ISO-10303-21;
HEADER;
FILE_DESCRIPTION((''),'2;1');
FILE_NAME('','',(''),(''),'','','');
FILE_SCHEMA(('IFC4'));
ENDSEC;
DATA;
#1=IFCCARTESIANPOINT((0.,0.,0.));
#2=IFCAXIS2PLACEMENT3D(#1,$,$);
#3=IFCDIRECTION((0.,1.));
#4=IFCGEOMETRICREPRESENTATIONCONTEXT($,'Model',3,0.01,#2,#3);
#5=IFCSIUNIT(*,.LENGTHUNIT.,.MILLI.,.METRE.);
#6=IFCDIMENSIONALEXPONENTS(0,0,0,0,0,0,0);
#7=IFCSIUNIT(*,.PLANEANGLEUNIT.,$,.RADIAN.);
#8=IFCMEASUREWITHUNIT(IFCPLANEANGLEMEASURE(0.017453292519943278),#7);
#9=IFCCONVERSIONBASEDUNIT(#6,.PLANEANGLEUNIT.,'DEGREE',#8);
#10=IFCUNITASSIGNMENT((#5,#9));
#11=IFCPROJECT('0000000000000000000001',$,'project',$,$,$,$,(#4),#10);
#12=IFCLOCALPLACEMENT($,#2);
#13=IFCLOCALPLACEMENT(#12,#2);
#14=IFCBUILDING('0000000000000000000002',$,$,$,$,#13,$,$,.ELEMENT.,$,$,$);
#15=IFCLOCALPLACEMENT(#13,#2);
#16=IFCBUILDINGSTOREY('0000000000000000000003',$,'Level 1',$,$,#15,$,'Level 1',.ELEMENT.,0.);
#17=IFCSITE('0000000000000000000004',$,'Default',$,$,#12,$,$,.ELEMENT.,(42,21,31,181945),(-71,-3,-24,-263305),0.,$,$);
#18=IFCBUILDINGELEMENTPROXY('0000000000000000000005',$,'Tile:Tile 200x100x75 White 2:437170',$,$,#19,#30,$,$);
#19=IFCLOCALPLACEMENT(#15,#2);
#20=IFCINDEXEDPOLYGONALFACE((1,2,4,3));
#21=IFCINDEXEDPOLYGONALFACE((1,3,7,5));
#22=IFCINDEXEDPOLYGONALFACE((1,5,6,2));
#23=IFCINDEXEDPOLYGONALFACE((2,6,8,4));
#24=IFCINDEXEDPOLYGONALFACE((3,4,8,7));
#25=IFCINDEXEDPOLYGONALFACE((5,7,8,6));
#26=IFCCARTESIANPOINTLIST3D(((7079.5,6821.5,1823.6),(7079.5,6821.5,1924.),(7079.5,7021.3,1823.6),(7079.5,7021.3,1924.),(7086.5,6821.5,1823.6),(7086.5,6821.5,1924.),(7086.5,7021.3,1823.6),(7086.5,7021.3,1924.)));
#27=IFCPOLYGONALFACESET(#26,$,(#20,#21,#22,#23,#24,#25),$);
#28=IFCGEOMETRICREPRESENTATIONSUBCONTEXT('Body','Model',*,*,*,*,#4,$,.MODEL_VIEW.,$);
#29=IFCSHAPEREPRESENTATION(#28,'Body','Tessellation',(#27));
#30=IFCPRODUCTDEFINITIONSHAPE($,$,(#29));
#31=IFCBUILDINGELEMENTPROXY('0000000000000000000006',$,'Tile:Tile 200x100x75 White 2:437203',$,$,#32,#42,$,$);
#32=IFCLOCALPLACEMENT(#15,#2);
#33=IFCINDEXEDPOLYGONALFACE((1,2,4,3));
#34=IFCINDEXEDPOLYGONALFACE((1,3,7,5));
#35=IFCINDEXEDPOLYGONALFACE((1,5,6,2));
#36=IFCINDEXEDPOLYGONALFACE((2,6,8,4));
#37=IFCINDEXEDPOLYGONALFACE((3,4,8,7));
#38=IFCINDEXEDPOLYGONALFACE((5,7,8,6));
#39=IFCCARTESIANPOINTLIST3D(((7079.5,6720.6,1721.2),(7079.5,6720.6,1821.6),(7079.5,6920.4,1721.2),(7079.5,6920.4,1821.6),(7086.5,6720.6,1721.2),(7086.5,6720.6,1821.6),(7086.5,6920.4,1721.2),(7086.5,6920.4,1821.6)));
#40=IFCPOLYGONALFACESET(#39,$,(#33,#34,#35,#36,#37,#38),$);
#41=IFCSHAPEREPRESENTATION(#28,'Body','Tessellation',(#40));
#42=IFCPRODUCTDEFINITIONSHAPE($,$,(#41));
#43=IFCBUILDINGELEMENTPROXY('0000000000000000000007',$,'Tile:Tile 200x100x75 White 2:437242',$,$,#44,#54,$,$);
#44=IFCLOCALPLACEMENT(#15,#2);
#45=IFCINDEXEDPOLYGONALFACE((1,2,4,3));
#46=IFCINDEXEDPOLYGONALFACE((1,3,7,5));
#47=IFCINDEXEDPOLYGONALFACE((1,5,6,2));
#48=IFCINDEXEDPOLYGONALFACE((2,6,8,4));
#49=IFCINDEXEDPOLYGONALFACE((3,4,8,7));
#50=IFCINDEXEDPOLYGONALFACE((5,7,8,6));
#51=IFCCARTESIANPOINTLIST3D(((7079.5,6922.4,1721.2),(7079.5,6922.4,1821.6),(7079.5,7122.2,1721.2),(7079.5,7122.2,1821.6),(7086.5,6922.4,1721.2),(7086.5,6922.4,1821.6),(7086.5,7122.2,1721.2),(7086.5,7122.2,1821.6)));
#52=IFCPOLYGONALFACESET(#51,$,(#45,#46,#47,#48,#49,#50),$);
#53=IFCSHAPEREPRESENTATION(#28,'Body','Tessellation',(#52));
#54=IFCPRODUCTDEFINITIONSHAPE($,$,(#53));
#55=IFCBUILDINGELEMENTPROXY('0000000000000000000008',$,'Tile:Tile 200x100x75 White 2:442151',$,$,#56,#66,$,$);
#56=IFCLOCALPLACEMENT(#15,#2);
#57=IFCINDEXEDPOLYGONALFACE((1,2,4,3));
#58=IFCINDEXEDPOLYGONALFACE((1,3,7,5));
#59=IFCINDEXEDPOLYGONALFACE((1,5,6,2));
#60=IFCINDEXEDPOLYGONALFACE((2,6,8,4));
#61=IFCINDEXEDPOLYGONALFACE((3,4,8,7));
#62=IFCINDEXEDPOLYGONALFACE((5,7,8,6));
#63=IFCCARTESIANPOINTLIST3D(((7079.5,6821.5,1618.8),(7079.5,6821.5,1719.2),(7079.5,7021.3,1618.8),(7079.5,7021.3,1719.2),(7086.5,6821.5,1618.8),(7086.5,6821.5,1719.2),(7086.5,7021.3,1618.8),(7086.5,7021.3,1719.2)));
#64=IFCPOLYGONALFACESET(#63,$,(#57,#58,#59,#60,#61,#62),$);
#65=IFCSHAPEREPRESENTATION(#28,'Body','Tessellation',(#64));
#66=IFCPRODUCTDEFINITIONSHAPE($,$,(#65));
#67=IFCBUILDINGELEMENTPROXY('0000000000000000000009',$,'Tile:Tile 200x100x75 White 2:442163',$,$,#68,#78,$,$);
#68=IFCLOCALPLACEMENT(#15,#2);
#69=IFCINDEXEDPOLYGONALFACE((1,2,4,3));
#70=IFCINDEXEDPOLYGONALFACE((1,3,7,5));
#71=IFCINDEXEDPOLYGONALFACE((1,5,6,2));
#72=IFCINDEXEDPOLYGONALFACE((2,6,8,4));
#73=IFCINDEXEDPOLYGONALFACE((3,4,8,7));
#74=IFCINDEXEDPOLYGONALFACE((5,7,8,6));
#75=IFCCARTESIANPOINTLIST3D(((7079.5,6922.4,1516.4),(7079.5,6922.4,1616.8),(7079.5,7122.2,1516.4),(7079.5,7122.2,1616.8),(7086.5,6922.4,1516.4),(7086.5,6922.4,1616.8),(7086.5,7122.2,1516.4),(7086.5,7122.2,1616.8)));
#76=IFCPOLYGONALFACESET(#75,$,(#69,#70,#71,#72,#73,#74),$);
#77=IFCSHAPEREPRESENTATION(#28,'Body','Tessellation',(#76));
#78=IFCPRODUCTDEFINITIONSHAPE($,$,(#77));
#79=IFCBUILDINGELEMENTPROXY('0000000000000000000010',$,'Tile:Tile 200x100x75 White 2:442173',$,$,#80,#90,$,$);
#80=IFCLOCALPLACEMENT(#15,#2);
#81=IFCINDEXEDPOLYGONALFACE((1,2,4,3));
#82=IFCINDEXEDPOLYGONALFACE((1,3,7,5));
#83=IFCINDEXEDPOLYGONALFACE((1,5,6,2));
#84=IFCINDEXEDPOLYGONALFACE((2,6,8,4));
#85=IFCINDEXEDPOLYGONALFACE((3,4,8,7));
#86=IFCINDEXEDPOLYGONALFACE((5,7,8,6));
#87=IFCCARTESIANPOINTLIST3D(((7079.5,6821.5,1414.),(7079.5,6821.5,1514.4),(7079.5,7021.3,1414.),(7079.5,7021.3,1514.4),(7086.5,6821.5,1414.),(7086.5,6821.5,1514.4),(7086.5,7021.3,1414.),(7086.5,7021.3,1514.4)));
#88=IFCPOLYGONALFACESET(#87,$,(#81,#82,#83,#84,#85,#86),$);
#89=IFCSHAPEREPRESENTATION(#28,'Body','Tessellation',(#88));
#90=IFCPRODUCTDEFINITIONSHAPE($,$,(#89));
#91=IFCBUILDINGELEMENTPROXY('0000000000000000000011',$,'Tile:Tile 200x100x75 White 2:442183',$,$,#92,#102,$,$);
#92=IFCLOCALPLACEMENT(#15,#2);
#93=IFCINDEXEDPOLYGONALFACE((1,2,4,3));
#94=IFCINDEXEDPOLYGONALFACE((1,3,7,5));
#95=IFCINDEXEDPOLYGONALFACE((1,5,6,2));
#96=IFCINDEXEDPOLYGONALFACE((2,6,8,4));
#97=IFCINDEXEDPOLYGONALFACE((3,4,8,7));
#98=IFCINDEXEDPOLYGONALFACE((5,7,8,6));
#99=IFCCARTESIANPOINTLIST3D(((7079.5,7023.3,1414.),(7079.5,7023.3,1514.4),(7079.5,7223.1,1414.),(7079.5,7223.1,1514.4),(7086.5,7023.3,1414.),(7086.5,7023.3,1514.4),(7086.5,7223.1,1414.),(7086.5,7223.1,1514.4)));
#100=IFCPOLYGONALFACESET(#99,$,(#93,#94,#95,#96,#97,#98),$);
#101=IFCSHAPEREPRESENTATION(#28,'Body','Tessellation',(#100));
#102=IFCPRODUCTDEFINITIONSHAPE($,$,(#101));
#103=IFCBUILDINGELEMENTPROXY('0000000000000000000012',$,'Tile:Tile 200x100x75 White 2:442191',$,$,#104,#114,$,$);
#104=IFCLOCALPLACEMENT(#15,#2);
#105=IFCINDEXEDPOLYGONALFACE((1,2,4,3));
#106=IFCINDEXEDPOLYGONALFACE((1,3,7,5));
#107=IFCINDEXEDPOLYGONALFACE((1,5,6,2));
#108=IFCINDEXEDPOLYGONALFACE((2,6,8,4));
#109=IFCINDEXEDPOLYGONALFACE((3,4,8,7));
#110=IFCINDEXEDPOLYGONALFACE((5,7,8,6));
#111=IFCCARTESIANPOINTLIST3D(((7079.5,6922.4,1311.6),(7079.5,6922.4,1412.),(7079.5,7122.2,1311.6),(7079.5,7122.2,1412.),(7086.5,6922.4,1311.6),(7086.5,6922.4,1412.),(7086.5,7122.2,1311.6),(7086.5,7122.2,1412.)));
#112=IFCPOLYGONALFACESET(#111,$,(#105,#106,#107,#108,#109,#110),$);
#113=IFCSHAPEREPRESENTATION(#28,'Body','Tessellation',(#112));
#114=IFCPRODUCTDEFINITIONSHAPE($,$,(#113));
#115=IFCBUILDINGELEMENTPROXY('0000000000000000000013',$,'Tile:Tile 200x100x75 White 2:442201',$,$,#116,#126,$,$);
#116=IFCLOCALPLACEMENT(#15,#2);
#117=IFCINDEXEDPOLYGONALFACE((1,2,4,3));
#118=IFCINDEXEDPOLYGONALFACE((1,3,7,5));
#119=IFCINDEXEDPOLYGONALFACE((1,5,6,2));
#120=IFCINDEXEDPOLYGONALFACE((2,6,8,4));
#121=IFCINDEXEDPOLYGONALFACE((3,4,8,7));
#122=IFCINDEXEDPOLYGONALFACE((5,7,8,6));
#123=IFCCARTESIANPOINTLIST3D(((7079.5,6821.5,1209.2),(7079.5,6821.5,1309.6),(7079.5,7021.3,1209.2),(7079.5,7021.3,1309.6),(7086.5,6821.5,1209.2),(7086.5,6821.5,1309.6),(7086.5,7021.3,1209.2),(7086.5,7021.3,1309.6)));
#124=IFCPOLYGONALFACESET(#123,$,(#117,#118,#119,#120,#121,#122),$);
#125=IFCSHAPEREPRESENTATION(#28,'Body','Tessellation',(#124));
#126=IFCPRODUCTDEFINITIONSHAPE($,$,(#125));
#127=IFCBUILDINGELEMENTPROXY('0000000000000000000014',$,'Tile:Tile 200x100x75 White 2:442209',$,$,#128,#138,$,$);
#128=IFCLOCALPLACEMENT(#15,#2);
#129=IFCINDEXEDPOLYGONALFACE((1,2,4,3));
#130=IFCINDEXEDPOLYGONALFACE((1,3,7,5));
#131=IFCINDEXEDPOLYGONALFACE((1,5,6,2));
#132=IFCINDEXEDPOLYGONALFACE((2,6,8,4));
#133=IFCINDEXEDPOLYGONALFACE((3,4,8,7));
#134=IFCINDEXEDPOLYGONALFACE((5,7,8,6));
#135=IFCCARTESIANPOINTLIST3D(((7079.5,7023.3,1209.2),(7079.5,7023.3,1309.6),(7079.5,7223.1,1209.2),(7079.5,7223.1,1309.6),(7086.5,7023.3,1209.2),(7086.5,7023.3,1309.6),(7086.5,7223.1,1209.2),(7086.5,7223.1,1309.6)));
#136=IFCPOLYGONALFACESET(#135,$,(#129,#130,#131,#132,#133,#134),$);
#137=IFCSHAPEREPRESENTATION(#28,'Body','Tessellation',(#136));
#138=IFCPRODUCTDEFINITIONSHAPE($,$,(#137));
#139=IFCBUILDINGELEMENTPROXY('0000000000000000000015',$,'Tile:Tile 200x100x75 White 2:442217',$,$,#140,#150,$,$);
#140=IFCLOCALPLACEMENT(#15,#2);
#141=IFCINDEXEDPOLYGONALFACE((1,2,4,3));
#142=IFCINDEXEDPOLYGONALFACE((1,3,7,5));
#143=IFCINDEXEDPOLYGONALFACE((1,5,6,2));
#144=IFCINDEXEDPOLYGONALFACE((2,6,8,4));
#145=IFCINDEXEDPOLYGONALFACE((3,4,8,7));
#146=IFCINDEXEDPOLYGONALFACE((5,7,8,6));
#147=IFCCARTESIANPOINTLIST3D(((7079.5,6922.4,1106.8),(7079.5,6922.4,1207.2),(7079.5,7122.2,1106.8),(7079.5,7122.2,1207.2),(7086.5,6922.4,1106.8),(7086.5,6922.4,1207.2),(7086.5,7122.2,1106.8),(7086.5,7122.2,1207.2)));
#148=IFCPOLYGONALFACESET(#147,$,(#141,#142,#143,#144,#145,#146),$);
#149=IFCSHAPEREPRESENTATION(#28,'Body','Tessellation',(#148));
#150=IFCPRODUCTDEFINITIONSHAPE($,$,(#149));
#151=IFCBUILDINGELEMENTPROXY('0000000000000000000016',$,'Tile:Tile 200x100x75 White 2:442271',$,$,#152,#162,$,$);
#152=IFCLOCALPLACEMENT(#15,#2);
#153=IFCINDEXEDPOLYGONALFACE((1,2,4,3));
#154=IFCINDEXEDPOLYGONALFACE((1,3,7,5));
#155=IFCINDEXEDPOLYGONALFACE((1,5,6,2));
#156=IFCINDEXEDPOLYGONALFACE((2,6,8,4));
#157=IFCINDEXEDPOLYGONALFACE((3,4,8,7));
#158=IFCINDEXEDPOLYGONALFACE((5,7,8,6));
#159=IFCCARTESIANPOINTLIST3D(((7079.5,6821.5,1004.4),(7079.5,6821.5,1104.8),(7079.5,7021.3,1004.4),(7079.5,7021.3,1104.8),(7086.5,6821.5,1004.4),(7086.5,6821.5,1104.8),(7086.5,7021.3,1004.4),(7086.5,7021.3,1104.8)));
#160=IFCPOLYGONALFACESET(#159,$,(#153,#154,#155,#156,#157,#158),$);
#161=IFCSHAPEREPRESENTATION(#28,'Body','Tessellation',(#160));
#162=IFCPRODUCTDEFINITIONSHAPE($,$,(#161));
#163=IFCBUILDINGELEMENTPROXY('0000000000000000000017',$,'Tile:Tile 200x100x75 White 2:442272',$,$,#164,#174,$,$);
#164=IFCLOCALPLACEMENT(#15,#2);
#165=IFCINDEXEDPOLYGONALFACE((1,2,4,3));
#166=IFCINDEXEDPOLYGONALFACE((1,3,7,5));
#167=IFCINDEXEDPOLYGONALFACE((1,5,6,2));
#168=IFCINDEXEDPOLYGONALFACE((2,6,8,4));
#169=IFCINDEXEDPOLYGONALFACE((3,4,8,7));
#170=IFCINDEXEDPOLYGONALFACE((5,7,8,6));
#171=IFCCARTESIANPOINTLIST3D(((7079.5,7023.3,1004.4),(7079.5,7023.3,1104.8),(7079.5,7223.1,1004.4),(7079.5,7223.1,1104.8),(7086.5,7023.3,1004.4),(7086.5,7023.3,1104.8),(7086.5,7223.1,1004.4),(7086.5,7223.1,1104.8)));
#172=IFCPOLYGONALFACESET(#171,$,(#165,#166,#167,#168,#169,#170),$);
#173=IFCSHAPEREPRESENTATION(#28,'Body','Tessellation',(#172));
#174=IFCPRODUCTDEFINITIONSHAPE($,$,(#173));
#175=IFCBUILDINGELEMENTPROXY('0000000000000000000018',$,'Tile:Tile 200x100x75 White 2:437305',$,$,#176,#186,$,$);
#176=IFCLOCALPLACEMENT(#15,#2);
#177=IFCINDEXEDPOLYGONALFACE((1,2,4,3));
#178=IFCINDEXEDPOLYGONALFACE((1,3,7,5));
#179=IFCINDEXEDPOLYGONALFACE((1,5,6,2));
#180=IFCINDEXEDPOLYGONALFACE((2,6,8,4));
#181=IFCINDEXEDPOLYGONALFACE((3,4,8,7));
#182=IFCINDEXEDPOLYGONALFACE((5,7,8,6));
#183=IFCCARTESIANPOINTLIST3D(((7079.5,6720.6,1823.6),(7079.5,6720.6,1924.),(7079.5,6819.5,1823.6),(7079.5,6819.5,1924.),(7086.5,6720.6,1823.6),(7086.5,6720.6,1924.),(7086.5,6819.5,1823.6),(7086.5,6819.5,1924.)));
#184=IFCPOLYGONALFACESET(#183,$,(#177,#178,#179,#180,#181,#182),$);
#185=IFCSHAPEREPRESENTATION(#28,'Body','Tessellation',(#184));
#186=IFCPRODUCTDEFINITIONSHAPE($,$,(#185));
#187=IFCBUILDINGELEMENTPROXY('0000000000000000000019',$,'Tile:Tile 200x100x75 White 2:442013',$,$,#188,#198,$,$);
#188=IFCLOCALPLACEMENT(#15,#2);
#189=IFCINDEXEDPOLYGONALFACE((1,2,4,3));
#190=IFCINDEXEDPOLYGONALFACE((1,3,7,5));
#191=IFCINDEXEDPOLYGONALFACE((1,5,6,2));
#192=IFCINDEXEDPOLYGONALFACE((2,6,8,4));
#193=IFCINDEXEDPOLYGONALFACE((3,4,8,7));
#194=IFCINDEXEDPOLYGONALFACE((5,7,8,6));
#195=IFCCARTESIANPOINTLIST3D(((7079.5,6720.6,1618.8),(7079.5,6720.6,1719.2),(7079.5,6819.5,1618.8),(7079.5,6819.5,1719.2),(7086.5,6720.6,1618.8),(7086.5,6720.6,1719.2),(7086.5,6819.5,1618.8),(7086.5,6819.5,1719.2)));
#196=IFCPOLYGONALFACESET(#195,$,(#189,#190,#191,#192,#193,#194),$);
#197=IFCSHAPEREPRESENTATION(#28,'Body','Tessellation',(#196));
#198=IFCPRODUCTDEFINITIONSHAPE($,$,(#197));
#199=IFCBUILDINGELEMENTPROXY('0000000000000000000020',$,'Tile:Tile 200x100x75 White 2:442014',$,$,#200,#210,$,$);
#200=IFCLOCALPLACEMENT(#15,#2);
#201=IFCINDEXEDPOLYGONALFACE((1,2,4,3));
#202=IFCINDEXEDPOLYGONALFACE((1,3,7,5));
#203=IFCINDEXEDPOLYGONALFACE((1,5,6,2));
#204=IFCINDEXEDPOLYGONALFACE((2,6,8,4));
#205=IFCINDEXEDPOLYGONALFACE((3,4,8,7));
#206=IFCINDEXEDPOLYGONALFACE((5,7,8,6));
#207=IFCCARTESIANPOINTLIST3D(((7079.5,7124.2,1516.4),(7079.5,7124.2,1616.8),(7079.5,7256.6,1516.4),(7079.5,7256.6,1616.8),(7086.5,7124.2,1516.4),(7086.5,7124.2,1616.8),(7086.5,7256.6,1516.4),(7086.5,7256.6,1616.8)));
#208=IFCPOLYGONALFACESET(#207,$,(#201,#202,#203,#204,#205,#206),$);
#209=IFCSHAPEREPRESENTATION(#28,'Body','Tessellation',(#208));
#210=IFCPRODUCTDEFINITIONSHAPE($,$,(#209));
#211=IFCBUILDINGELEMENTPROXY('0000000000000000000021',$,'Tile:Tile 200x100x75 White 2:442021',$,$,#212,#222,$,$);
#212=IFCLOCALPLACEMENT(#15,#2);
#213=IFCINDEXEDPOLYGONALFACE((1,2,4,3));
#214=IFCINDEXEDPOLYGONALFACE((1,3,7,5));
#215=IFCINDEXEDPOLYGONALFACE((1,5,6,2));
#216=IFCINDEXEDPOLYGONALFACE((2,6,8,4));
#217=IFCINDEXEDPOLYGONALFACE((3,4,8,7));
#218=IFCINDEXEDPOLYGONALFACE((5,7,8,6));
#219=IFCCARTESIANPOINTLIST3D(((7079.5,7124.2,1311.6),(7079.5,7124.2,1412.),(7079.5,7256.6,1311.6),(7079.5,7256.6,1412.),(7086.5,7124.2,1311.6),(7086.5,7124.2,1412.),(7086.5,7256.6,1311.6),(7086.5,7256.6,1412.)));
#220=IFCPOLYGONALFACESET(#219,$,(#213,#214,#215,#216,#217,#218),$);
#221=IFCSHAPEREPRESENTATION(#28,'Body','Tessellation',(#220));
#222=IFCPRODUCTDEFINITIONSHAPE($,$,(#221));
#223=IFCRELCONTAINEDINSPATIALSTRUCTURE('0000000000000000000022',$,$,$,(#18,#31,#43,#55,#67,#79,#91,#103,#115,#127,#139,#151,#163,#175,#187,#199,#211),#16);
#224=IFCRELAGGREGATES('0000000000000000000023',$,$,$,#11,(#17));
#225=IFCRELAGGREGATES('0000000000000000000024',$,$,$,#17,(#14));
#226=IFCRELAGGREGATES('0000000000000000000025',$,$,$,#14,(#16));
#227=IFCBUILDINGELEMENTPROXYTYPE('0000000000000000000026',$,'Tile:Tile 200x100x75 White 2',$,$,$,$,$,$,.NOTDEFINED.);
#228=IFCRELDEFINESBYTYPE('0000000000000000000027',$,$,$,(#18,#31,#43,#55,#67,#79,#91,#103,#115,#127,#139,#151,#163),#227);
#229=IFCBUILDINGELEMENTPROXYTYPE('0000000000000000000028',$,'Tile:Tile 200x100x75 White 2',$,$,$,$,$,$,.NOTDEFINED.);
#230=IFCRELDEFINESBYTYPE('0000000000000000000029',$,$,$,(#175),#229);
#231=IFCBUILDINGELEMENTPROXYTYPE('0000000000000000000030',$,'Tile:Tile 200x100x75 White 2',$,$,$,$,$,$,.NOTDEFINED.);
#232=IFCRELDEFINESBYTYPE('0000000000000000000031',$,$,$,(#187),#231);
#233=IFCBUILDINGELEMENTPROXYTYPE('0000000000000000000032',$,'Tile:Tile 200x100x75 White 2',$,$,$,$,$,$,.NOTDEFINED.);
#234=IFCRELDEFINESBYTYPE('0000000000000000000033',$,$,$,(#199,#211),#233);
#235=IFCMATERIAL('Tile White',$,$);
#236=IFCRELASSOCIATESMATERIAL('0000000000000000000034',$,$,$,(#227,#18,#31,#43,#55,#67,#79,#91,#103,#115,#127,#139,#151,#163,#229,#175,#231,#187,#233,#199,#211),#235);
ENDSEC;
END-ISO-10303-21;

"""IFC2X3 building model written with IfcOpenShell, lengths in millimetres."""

from ifc_helpers import new_model, entity, si_unit, converted_unit, direction, frame, frame_2d, origin, origin_2d_with_axis, place, context, subcontext, project, spatial, rectangle, extrude, source, transform, mapped, material, type_object, type_shapes, element, save


model = new_model("IFC2X3")

# Units and contexts
model_context = context("Model", 3, precision=0.01, world=origin(), true_north=direction((0.0, 1.0)))
body_context = subcontext(model_context, "Body", "Model", "MODEL_VIEW")
ifc_project = project(units=[si_unit("LENGTHUNIT", "METRE", prefix="MILLI"), converted_unit("PLANEANGLEUNIT", "DEGREE", entity("IfcPlaneAngleMeasure", 0.017453292519943278), si_unit("PLANEANGLEUNIT", "RADIAN"), dimensions=[0, 0, 0, 0, 0, 0, 0])], contexts=[model_context])

# Site, building, storey
site_placement = place(None, origin())
site = spatial("IfcSite", under=ifc_project, at=site_placement, Name="Default", CompositionType="ELEMENT", RefLatitude=(42, 21, 31, 181945), RefLongitude=(-71, -3, -24, -263305), RefElevation=0.0)
building_placement = place(site_placement, origin())
building = spatial("IfcBuilding", under=site, at=building_placement, CompositionType="ELEMENT")
storey_placement = place(building_placement, origin())
storey = spatial("IfcBuildingStorey", under=building, at=storey_placement, Name="Level 1", LongName="Level 1", CompositionType="ELEMENT", Elevation=0.0)

# Building element proxies
ifc_material_1 = material(Name="Tile White")
building_element_proxy_type_1 = type_object("IfcBuildingElementProxyType", Name="Tile:Tile 200x100x75 White 2", PredefinedType="NOTDEFINED", material=ifc_material_1)
shared_shape_1 = source(origin(), body_context, "Body", "SweptSolid", [
    extrude(rectangle(XDim=199.8, YDim=100.4, at=frame_2d((0.0, 0.0), x_axis=(1.0, 0.0))), frame((-50.2, -99.9, 0.0), z_axis=(0.0, 0.0, 1.0), x_axis=(0.0, -1.0, 0.0)), (0.0, 0.0, 1.0), 7.0),
])
type_shapes(building_element_proxy_type_1, [shared_shape_1])
for number, where, z_axis, x_axis, name in (
    (1, (7086.5, 7021.3, 1924.0), (-1.0, 0.0, 0.0), (0.0, 0.0, 1.0), "Tile:Tile 200x100x75 White 2:437170"),
    (2, (7086.5, 6920.4, 1821.6), (-1.0, 0.0, 0.0), (0.0, 0.0, 1.0), "Tile:Tile 200x100x75 White 2:437203"),
    (3, (7086.5, 7122.2, 1821.6), (-1.0, 0.0, 0.0), (0.0, 0.0, 1.0), "Tile:Tile 200x100x75 White 2:437242"),
    (4, (7086.5, 7021.3, 1719.2), (-1.0, 0.0, 0.0), (0.0, 0.0, 1.0), "Tile:Tile 200x100x75 White 2:442151"),
    (5, (7086.5, 7122.2, 1616.8), (-1.0, 0.0, 0.0), (0.0, 0.0, 1.0), "Tile:Tile 200x100x75 White 2:442163"),
    (6, (7086.5, 7021.3, 1514.4), (-1.0, 0.0, 0.0), (0.0, 0.0, 1.0), "Tile:Tile 200x100x75 White 2:442173"),
    (7, (7086.5, 7223.1, 1514.4), (-1.0, 0.0, 0.0), (0.0, 0.0, 1.0), "Tile:Tile 200x100x75 White 2:442183"),
    (8, (7086.5, 7122.2, 1412.0), (-1.0, 0.0, 0.0), (0.0, 0.0, 1.0), "Tile:Tile 200x100x75 White 2:442191"),
    (9, (7086.5, 7021.3, 1309.6), (-1.0, 0.0, 0.0), (0.0, 0.0, 1.0), "Tile:Tile 200x100x75 White 2:442201"),
    (10, (7086.5, 7223.1, 1309.6), (-1.0, 0.0, 0.0), (0.0, 0.0, 1.0), "Tile:Tile 200x100x75 White 2:442209"),
    (11, (7086.5, 7122.2, 1207.2), (-1.0, 0.0, 0.0), (0.0, 0.0, 1.0), "Tile:Tile 200x100x75 White 2:442217"),
    (12, (7086.5, 7021.3, 1104.8), (-1.0, 0.0, 0.0), (0.0, 0.0, 1.0), "Tile:Tile 200x100x75 White 2:442271"),
    (13, (7086.5, 7223.1, 1104.8), (-1.0, 0.0, 0.0), (0.0, 0.0, 1.0), "Tile:Tile 200x100x75 White 2:442272"),
):
    element("IfcBuildingElementProxy", number, at=place(storey_placement, frame(where, z_axis=z_axis, x_axis=x_axis)), inside=storey, type_object=building_element_proxy_type_1, material=ifc_material_1, Name=name, context=body_context, shape_type="MappedRepresentation", body=[
        mapped(shared_shape_1, transform((0.0, 0.0, 0.0), scale=1.0)),
    ])
building_element_proxy_type_2 = type_object("IfcBuildingElementProxyType", Name="Tile:Tile 200x100x75 White 2", PredefinedType="NOTDEFINED", material=ifc_material_1)
shared_shape_2 = source(origin(), body_context, "Body", "SweptSolid", [
    extrude(rectangle(XDim=98.9, YDim=100.4, at=origin_2d_with_axis()), frame((-50.2, -49.5, 0.0), z_axis=(0.0, 0.0, 1.0), x_axis=(0.0, -1.0, 0.0)), (0.0, 0.0, 1.0), 7.0),
])
type_shapes(building_element_proxy_type_2, [shared_shape_2])
proxy_1_placement = place(storey_placement, frame((7086.5, 6819.5, 1924.0), z_axis=(-1.0, 0.0, 0.0), x_axis=(0.0, 0.0, 1.0)))
element("IfcBuildingElementProxy", 14, at=proxy_1_placement, inside=storey, type_object=building_element_proxy_type_2, material=ifc_material_1, Name="Tile:Tile 200x100x75 White 2:437305", context=body_context, shape_type="MappedRepresentation", body=[
    mapped(shared_shape_2, transform((0.0, 0.0, 0.0), scale=1.0)),
])
building_element_proxy_type_3 = type_object("IfcBuildingElementProxyType", Name="Tile:Tile 200x100x75 White 2", PredefinedType="NOTDEFINED", material=ifc_material_1)
shared_shape_3 = source(origin(), body_context, "Body", "SweptSolid", [
    extrude(rectangle(XDim=100.4, YDim=98.9, at=origin_2d_with_axis()), frame((-50.2, 49.5, 0.0)), (0.0, 0.0, 1.0), 7.0),
])
type_shapes(building_element_proxy_type_3, [shared_shape_3])
proxy_2_placement = place(storey_placement, frame((7086.5, 6720.6, 1719.2), z_axis=(-1.0, 0.0, 0.0), x_axis=(0.0, 0.0, 1.0)))
element("IfcBuildingElementProxy", 15, at=proxy_2_placement, inside=storey, type_object=building_element_proxy_type_3, material=ifc_material_1, Name="Tile:Tile 200x100x75 White 2:442013", context=body_context, shape_type="MappedRepresentation", body=[
    mapped(shared_shape_3, transform((0.0, 0.0, 0.0), scale=1.0)),
])
building_element_proxy_type_4 = type_object("IfcBuildingElementProxyType", Name="Tile:Tile 200x100x75 White 2", PredefinedType="NOTDEFINED", material=ifc_material_1)
shared_shape_4 = source(origin(), body_context, "Body", "SweptSolid", [
    extrude(rectangle(XDim=100.4, YDim=132.4, at=frame_2d((0.0, 0.0), x_axis=(1.0, 0.0))), frame((-50.2, 66.2, 0.0)), (0.0, 0.0, 1.0), 7.0),
])
type_shapes(building_element_proxy_type_4, [shared_shape_4])
for number, where, z_axis, x_axis, name in (
    (16, (7086.5, 7124.2, 1616.8), (-1.0, 0.0, 0.0), (0.0, 0.0, 1.0), "Tile:Tile 200x100x75 White 2:442014"),
    (17, (7086.5, 7124.2, 1412.0), (-1.0, 0.0, 0.0), (0.0, 0.0, 1.0), "Tile:Tile 200x100x75 White 2:442021"),
):
    element("IfcBuildingElementProxy", number, at=place(storey_placement, frame(where, z_axis=z_axis, x_axis=x_axis)), inside=storey, type_object=building_element_proxy_type_4, material=ifc_material_1, Name=name, context=body_context, shape_type="MappedRepresentation", body=[
        mapped(shared_shape_4, transform((0.0, 0.0, 0.0), scale=1.0)),
    ])

save(model, "model.ifc")
